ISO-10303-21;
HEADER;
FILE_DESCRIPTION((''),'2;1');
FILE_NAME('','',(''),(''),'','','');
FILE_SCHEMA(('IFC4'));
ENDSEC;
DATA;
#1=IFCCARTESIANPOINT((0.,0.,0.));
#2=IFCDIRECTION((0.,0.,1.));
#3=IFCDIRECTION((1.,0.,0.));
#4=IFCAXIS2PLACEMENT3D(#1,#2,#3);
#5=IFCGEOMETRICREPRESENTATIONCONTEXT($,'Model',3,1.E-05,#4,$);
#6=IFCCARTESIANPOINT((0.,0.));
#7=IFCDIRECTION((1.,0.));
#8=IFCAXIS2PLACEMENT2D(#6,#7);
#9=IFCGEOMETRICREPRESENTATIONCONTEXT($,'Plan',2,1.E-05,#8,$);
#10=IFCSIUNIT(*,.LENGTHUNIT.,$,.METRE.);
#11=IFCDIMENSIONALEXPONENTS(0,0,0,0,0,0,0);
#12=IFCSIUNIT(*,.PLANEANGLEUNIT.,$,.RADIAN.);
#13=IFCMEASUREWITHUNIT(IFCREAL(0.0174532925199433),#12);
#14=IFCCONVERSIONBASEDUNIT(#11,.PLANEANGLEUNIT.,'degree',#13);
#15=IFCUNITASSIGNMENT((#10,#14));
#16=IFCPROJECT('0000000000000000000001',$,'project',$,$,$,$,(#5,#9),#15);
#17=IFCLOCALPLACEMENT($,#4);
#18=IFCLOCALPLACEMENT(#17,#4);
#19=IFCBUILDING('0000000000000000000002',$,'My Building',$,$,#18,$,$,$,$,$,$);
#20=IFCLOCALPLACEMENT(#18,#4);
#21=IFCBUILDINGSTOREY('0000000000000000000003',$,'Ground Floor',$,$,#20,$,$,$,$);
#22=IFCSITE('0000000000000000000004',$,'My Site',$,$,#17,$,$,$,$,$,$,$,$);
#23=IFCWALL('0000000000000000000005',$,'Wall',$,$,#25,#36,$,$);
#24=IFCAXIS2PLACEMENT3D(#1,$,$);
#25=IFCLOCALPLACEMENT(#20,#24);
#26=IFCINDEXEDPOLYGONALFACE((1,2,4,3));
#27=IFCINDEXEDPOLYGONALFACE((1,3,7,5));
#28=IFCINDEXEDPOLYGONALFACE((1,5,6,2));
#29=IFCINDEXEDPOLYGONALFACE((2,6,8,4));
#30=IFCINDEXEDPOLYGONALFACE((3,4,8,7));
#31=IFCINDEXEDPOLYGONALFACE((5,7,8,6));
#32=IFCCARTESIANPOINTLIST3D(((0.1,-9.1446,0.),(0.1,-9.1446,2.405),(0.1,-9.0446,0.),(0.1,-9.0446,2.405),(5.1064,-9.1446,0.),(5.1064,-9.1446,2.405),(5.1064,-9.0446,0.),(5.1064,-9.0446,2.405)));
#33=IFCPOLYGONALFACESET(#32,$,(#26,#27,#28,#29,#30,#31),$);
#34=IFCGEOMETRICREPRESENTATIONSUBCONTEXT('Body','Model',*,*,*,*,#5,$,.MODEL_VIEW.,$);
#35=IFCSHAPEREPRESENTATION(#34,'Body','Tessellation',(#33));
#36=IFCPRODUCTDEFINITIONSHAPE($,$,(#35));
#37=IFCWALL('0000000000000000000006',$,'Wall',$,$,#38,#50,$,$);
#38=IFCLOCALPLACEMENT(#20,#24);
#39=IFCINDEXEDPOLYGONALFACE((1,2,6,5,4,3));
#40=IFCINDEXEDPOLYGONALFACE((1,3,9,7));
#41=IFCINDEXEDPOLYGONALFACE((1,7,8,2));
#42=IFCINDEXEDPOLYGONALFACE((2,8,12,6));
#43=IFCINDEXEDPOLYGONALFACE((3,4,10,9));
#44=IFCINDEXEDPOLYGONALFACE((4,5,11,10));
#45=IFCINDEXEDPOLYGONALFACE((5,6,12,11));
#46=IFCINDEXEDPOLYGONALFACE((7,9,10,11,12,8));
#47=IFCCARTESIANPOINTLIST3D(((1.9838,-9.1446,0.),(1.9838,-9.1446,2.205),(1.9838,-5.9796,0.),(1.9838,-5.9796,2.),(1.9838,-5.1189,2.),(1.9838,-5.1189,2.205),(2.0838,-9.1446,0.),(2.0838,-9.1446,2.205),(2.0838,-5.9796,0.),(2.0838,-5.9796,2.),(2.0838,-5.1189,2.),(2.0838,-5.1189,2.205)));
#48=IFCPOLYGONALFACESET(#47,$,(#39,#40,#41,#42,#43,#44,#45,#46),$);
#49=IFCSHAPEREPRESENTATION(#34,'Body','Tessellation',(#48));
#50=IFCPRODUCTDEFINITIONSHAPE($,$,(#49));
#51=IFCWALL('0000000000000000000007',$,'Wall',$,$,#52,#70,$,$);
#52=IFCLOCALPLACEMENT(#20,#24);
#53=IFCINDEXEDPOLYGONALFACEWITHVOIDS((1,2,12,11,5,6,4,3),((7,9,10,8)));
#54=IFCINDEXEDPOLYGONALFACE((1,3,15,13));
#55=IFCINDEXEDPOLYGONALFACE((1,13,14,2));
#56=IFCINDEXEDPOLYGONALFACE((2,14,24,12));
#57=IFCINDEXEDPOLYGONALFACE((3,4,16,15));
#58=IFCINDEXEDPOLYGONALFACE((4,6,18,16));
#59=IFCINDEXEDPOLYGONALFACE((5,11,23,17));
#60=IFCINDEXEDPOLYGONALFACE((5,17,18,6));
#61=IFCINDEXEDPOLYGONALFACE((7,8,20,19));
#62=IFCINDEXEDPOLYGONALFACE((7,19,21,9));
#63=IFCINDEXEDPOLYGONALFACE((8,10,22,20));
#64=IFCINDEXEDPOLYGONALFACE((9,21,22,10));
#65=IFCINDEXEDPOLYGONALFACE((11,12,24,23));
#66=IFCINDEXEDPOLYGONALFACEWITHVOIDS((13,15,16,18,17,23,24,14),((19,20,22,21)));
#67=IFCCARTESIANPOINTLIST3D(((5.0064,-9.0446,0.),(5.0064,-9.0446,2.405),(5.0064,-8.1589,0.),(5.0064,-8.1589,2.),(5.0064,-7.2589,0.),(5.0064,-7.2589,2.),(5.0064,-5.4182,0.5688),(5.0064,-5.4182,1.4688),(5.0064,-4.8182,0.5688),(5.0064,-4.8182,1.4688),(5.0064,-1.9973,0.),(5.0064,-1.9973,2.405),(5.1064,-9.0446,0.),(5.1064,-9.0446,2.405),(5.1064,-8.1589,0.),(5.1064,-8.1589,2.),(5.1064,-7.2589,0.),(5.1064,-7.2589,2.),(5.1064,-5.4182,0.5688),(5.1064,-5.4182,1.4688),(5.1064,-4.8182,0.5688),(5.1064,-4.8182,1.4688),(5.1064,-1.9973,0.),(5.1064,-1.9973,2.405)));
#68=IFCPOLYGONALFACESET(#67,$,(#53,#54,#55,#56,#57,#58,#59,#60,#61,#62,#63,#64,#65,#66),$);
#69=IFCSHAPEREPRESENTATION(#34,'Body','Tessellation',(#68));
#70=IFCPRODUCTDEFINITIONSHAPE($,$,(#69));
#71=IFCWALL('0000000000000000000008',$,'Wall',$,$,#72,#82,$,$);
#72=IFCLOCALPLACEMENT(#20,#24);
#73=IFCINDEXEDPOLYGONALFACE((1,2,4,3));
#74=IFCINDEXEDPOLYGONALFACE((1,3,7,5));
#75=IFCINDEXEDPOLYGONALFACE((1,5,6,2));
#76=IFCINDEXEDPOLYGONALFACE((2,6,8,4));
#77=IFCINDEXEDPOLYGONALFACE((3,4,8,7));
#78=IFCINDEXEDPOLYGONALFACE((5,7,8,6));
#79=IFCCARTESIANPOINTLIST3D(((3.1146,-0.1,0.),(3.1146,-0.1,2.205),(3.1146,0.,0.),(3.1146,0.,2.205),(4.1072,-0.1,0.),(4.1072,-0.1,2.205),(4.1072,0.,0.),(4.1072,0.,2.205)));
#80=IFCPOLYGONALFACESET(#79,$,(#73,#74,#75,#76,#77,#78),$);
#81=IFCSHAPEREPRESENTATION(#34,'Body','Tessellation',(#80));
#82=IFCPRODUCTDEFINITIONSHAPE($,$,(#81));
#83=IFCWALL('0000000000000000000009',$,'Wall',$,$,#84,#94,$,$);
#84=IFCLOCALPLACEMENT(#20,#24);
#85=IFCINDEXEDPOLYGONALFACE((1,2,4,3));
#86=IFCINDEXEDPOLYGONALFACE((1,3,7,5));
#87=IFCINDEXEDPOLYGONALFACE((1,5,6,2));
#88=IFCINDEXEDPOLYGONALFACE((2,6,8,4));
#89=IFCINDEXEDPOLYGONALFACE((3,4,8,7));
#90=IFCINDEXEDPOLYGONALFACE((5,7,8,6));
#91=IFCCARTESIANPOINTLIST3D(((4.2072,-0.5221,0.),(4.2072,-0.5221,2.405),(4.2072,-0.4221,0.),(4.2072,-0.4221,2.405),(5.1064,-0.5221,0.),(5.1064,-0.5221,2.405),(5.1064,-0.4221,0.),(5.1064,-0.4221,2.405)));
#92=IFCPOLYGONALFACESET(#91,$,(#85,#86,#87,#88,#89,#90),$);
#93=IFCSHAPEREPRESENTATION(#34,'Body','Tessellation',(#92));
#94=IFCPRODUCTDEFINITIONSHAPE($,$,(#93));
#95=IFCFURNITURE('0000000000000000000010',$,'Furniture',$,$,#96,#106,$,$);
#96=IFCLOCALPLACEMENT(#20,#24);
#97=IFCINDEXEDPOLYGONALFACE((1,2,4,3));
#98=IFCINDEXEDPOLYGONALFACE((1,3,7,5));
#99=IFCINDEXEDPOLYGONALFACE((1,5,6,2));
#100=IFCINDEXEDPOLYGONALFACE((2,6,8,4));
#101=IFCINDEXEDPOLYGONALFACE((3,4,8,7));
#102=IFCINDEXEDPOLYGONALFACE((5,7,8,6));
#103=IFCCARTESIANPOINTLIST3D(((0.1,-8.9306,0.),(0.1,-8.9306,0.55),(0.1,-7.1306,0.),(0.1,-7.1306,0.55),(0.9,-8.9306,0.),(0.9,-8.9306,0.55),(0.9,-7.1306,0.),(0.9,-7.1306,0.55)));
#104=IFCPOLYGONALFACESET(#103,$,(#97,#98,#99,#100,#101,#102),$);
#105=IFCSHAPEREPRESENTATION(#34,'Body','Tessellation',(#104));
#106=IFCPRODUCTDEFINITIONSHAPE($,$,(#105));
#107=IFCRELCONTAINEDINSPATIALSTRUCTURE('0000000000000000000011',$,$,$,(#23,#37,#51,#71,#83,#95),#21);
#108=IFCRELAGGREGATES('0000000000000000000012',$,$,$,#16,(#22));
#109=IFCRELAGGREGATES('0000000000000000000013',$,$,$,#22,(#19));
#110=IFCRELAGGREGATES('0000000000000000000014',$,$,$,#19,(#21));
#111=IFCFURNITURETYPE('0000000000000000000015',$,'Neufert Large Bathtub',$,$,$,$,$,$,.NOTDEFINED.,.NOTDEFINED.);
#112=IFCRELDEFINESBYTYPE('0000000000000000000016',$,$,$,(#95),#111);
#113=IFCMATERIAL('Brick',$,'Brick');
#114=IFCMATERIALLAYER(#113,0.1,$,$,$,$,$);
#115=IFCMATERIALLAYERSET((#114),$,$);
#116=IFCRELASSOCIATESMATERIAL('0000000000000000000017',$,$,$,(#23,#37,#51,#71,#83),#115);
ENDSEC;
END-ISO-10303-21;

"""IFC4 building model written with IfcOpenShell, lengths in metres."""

from ifc_helpers import new_model, entity, si_unit, converted_unit, frame, origin_with_axes, origin_2d_with_axis, place, context, subcontext, project, spatial, line, indexed_curve, outline, extrude, source, transform, mapped, material, layer, layer_set, layer_usage, type_object, type_shapes, element, save


model = new_model("IFC4")

# Units and contexts
model_context = context("Model", 3, precision=1e-05, world=origin_with_axes())
plan_context = context("Plan", 2, precision=1e-05, world=origin_2d_with_axis())
body_context = subcontext(model_context, "Body", "Model", "MODEL_VIEW")
ifc_project = project(units=[si_unit("LENGTHUNIT", "METRE"), converted_unit("PLANEANGLEUNIT", "degree", entity("IfcReal", 0.0174532925199433), si_unit("PLANEANGLEUNIT", "RADIAN"), dimensions=[0, 0, 0, 0, 0, 0, 0])], contexts=[model_context, plan_context])

# Site, building, storey
site_placement = place(None, origin_with_axes())
site = spatial("IfcSite", under=ifc_project, at=site_placement, Name="My Site")
building_placement = place(site_placement, origin_with_axes())
building = spatial("IfcBuilding", under=site, at=building_placement, Name="My Building")
storey_placement = place(building_placement, origin_with_axes())
storey = spatial("IfcBuildingStorey", under=building, at=storey_placement, Name="Ground Floor")

# Shared definitions
ifc_material_1 = material(Name="Brick", Category="Brick")
ifc_layer_1 = layer(ifc_material_1, 0.1)
ifc_layer_set_1 = layer_set([ifc_layer_1])

# Shared definitions
shared_shape_1 = source(origin_with_axes(), body_context, "Body", "SweptSolid", [
    extrude(outline(indexed_curve([(0.0, 0.0), (0.9, 0.0), (0.9, 2.0), (0.0, 2.0)], segments=[line(1, 2, 3, 4, 1)])), frame((0.0, -0.1, 0.0), z_axis=(0.0, -1.0, 0.0), x_axis=(1.0, 0.0, 0.0)), (0.0, 0.0, -1.0), 0.3),
])

# Shared definitions
shared_shape_2 = source(origin_with_axes(), body_context, "Body", "SweptSolid", [
    extrude(outline(indexed_curve([(0.0, 0.0), (0.6, 0.0), (0.6, 0.9), (0.0, 0.9)], segments=[line(1, 2, 3, 4, 1)])), frame((0.0, -0.1, 0.0), z_axis=(0.0, -1.0, 0.0), x_axis=(1.0, 0.0, 0.0)), (0.0, 0.0, -1.0), 0.3),
])

# Wall
ifc_layer_usage_1 = layer_usage(ifc_layer_set_1, "AXIS2", "POSITIVE", 0.0)
wall_1_placement = place(storey_placement, frame((0.1, -9.1446, 0.0), z_axis=(0.0, 0.0, 1.0), x_axis=(1.0, -0.000001, 0.0)))
element("IfcWall", 1, at=wall_1_placement, inside=storey, material=ifc_layer_usage_1, Name="Wall", context=body_context, shape_type="SweptSolid", body=[
    extrude(outline(indexed_curve([(0.0, 0.0), (0.0, 0.1), (5.0064, 0.1), (5.0064, 0.0), (0.0, 0.0)], self_intersect=False)), origin_with_axes(), (0.0, 0.0, 1.0), 2.405),
])

# Wall, opening
ifc_layer_usage_2 = layer_usage(ifc_layer_set_1, "AXIS2", "POSITIVE", 0.0)
wall_2_placement = place(storey_placement, frame((1.9838, -5.1189, 0.0), z_axis=(0.0, 0.0, 1.0), x_axis=(-0.000001, -1.0, 0.0)))
wall_2 = element("IfcWall", 2, at=wall_2_placement, inside=storey, material=ifc_layer_usage_2, Name="Wall", context=body_context, shape_type="SweptSolid", body=[
    extrude(outline(indexed_curve([(0.0, 0.0), (0.0, 0.1), (4.0257, 0.1), (4.0257, 0.0), (0.0, 0.0)], self_intersect=False)), origin_with_axes(), (0.0, 0.0, 1.0), 2.205),
])
opening_1_placement = place(wall_2_placement, frame((0.8606, 0.1, 0.0), z_axis=(0.0, 0.0, 1.0), x_axis=(-1.0, 0.0, 0.0)))
element("IfcOpeningElement", 3, at=opening_1_placement, cuts=wall_2, PredefinedType="OPENING", context=body_context, shape_type="MappedRepresentation", body=[
    mapped(shared_shape_1, transform((0.0, 0.0, 0.0), x_axis=(1.0, 0.0, 0.0), y_axis=(0.0, 1.0, 0.0), z_axis=(0.0, 0.0, 1.0), scale=1.0)),
])

# Wall, openings
ifc_layer_usage_3 = layer_usage(ifc_layer_set_1, "AXIS2", "POSITIVE", 0.0)
wall_3_placement = place(storey_placement, frame((5.1064, -9.0446, 0.0), z_axis=(0.0, 0.0, 1.0), x_axis=(0.000001, 1.0, 0.0)))
wall_3 = element("IfcWall", 4, at=wall_3_placement, inside=storey, material=ifc_layer_usage_3, Name="Wall", context=body_context, shape_type="SweptSolid", body=[
    extrude(outline(indexed_curve([(0.0, 0.0), (0.0, 0.1), (7.0473, 0.1), (7.0473, 0.0), (0.0, 0.0)], self_intersect=False)), origin_with_axes(), (0.0, 0.0, 1.0), 2.405),
])
opening_2_placement = place(wall_3_placement, frame((1.7858, 0.1, 0.0), z_axis=(0.0, 0.0, 1.0), x_axis=(-1.0, 0.0, 0.0)))
element("IfcOpeningElement", 5, at=opening_2_placement, cuts=wall_3, PredefinedType="OPENING", context=body_context, shape_type="MappedRepresentation", body=[
    mapped(shared_shape_1, transform((0.0, 0.0, 0.0), x_axis=(1.0, 0.0, 0.0), y_axis=(0.0, 1.0, 0.0), z_axis=(0.0, 0.0, 1.0), scale=1.0)),
])
opening_3_placement = place(wall_3_placement, frame((3.6265, 0.0, 0.5688), z_axis=(0.0, 0.0, 1.0), x_axis=(1.0, 0.0, 0.0)))
element("IfcOpeningElement", 6, at=opening_3_placement, cuts=wall_3, PredefinedType="OPENING", context=body_context, shape_type="MappedRepresentation", body=[
    mapped(shared_shape_2, transform((0.0, 0.0, 0.0), x_axis=(1.0, 0.0, 0.0), y_axis=(0.0, 1.0, 0.0), z_axis=(0.0, 0.0, 1.0), scale=1.0)),
])

# Walls
ifc_layer_usage_4 = layer_usage(ifc_layer_set_1, "AXIS2", "POSITIVE", 0.0)
wall_4_placement = place(storey_placement, frame((4.1072, 0.0, 0.0), z_axis=(0.0, 0.0, 1.0), x_axis=(-1.0, 0.000001, 0.0)))
element("IfcWall", 7, at=wall_4_placement, inside=storey, material=ifc_layer_usage_4, Name="Wall", context=body_context, shape_type="SweptSolid", body=[
    extrude(outline(indexed_curve([(0.0, 0.0), (0.0, 0.1), (0.9925, 0.1), (0.9925, 0.0), (0.0, 0.0)], self_intersect=False)), origin_with_axes(), (0.0, 0.0, 1.0), 2.205),
])
ifc_layer_usage_5 = layer_usage(ifc_layer_set_1, "AXIS2", "POSITIVE", 0.0)
wall_5_placement = place(storey_placement, frame((5.1064, -0.4221, 0.0), z_axis=(0.0, 0.0, 1.0), x_axis=(-1.0, 0.000001, 0.0)))
element("IfcWall", 8, at=wall_5_placement, inside=storey, material=ifc_layer_usage_5, Name="Wall", context=body_context, shape_type="SweptSolid", body=[
    extrude(outline(indexed_curve([(0.0, 0.0), (0.0, 0.1), (0.8992, 0.1), (0.8992, 0.0), (0.0, 0.0)], self_intersect=False)), origin_with_axes(), (0.0, 0.0, 1.0), 2.405),
])

# Furniture
furniture_type_1 = type_object("IfcFurnitureType", Name="Neufert Large Bathtub", AssemblyPlace="NOTDEFINED", PredefinedType="NOTDEFINED")
shared_shape_3 = source(origin_with_axes(), body_context, "Body", "SweptSolid", [
    extrude(outline(indexed_curve([(0.0, 0.0), (0.0, 0.8), (1.8, 0.8), (1.8, 0.0)], segments=[line(1, 2), line(2, 3), line(3, 4), line(4, 1)])), origin_with_axes(), (0.0, 0.0, 1.0), 0.55),
])
type_shapes(furniture_type_1, [shared_shape_3])
furniture_1_placement = place(storey_placement, frame((0.1, -7.1306, 0.0), z_axis=(0.0, 0.0, 1.0), x_axis=(0.0, -1.0, 0.0)))
element("IfcFurniture", 9, at=furniture_1_placement, inside=storey, type_object=furniture_type_1, Name="Furniture", context=body_context, shape_type="MappedRepresentation", body=[
    mapped(shared_shape_3, transform((0.0, 0.0, 0.0), x_axis=(1.0, 0.0, 0.0), y_axis=(0.0, 1.0, 0.0), z_axis=(0.0, 0.0, 1.0), scale=1.0)),
])

save(model, "model.ifc")
